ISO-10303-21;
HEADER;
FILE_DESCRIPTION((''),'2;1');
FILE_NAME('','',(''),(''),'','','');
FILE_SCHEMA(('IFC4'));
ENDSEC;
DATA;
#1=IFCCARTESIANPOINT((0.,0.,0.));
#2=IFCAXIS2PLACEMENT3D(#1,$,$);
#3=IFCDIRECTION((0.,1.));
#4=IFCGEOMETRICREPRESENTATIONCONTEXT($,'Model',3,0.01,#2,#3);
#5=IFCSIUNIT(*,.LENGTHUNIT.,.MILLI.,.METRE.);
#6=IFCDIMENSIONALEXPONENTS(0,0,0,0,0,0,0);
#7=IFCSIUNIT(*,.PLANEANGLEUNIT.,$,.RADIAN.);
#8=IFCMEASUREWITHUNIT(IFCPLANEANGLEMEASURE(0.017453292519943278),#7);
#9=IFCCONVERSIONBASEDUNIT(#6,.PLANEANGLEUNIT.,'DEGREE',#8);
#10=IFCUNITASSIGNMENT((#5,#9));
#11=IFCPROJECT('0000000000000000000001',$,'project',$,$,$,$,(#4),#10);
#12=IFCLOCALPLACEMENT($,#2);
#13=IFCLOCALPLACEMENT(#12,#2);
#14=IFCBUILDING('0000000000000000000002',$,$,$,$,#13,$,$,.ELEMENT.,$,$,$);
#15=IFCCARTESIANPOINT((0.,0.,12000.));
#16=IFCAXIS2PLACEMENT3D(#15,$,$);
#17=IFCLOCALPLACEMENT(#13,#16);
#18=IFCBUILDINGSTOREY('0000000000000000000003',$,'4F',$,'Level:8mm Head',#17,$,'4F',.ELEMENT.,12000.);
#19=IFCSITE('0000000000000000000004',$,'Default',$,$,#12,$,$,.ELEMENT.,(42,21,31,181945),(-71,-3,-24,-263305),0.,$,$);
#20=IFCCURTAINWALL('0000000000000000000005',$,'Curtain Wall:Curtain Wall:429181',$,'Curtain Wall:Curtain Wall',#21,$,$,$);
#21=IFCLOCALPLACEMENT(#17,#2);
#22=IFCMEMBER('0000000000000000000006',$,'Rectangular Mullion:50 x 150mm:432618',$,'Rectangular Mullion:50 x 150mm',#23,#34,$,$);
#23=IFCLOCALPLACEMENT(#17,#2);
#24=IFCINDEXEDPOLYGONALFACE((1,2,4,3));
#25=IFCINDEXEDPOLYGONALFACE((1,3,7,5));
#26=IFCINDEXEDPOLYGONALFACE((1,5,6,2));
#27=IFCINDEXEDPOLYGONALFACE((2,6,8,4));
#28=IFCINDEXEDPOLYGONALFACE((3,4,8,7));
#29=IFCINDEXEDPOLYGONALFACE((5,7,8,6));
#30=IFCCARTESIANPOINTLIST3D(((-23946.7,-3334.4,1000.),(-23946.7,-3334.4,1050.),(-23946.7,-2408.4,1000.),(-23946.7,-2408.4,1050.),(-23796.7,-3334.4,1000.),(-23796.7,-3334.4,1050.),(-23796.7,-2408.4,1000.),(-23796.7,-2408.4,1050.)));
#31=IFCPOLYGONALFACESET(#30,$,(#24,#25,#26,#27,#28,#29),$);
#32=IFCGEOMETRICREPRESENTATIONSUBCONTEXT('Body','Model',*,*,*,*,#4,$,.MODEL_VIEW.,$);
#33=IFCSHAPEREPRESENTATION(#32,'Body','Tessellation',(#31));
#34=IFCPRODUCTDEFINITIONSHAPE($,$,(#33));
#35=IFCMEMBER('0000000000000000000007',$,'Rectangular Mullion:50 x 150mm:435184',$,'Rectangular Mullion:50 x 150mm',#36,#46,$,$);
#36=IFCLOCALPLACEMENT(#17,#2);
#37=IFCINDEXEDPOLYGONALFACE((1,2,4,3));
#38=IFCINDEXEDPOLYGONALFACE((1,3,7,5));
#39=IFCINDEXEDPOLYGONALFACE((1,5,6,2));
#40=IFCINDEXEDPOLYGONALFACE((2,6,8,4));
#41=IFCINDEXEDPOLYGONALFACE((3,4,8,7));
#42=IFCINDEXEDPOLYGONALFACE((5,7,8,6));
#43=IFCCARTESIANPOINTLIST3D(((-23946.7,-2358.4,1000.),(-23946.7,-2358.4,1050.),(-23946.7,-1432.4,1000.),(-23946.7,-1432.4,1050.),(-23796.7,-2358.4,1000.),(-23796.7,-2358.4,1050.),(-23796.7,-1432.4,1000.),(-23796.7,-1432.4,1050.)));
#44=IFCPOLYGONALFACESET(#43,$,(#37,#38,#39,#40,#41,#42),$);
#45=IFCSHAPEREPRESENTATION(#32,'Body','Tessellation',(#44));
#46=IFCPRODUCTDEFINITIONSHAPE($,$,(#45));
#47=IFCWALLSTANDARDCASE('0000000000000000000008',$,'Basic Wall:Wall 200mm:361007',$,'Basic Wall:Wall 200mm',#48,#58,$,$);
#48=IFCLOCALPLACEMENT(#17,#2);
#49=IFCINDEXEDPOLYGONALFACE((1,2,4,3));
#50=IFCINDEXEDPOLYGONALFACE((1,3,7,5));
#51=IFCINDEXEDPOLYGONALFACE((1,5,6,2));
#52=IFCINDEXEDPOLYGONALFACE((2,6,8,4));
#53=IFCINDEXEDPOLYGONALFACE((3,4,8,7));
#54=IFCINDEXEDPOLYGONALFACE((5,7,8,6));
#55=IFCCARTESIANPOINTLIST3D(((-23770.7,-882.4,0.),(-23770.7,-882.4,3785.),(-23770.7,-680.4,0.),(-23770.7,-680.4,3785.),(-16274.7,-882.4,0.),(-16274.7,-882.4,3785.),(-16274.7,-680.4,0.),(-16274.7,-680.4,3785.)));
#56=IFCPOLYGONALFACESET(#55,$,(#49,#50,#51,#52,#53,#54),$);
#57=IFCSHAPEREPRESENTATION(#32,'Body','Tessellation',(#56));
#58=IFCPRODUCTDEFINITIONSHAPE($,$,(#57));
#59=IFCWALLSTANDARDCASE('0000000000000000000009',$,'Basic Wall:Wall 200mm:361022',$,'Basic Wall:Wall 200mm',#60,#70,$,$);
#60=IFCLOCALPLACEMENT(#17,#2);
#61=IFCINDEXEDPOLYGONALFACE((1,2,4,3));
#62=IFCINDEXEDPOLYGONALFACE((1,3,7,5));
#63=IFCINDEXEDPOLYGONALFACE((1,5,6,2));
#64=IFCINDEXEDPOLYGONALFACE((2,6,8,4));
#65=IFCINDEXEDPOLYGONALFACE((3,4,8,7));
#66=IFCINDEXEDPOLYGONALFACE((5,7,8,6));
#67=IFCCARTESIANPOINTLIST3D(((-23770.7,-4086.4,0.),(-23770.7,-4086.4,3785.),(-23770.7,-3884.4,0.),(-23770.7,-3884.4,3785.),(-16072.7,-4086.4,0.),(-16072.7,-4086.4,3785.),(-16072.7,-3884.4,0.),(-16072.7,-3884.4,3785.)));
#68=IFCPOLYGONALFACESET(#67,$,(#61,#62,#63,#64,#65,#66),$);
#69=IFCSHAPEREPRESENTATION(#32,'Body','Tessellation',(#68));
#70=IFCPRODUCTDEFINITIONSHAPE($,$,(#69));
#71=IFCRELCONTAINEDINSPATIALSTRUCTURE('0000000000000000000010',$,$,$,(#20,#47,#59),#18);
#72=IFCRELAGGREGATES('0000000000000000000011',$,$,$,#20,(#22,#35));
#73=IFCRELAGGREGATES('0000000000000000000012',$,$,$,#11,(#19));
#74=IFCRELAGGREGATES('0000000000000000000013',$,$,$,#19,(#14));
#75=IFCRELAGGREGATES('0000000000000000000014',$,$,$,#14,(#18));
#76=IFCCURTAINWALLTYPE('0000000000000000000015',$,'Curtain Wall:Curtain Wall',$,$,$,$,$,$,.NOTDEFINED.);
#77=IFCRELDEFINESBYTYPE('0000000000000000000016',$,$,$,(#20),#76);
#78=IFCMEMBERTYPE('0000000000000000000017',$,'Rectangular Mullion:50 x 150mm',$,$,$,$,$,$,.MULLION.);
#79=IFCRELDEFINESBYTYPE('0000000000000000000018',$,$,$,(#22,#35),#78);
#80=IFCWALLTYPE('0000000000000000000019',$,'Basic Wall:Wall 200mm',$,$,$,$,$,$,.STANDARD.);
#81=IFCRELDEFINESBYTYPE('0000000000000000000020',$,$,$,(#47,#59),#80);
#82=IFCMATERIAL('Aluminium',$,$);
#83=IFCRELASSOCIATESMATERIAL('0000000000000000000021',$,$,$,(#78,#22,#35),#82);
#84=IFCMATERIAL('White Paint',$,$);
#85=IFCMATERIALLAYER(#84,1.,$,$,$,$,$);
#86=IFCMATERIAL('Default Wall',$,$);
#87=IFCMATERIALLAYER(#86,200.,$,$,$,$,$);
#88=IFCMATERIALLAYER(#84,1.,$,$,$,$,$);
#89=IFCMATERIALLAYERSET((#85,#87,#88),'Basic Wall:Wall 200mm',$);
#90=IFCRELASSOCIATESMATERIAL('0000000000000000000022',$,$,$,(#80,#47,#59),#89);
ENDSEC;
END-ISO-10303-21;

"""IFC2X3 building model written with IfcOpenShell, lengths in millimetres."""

from ifc_helpers import new_model, entity, si_unit, converted_unit, direction, frame, frame_2d, origin, origin_2d_with_axis, place, context, subcontext, project, spatial, polyline, rectangle, extrude, clip, bounded_halfspace, source, transform, mapped, material, layer, layer_set, layer_usage, type_object, type_shapes, element, aggregate, save


model = new_model("IFC2X3")

# Units and contexts
model_context = context("Model", 3, precision=0.01, world=origin(), true_north=direction((0.0, 1.0)))
body_context = subcontext(model_context, "Body", "Model", "MODEL_VIEW")
ifc_project = project(units=[si_unit("LENGTHUNIT", "METRE", prefix="MILLI"), converted_unit("PLANEANGLEUNIT", "DEGREE", entity("IfcPlaneAngleMeasure", 0.017453292519943278), si_unit("PLANEANGLEUNIT", "RADIAN"), dimensions=[0, 0, 0, 0, 0, 0, 0])], contexts=[model_context])

# Site, building, storey
site_placement = place(None, origin())
site = spatial("IfcSite", under=ifc_project, at=site_placement, Name="Default", CompositionType="ELEMENT", RefLatitude=(42, 21, 31, 181945), RefLongitude=(-71, -3, -24, -263305), RefElevation=0.0)
building_placement = place(site_placement, origin())
building = spatial("IfcBuilding", under=site, at=building_placement, CompositionType="ELEMENT")
storey_placement = place(building_placement, frame((0.0, 0.0, 12000.0)))
storey = spatial("IfcBuildingStorey", under=building, at=storey_placement, Name="4F", ObjectType="Level:8mm Head", LongName="4F", CompositionType="ELEMENT", Elevation=12000.0)

# Curtain wall, members
curtain_wall_type = type_object("IfcCurtainWallType", Name="Curtain Wall:Curtain Wall", PredefinedType="NOTDEFINED")
curtain_wall_placement = place(storey_placement, frame((0.0, 0.0, -12000.0)))
curtain_wall = element("IfcCurtainWall", 1, at=curtain_wall_placement, inside=storey, type_object=curtain_wall_type, Name="Curtain Wall:Curtain Wall:429181", ObjectType="Curtain Wall:Curtain Wall")
ifc_material_1 = material(Name="Aluminium")
member_type_1 = type_object("IfcMemberType", Name="Rectangular Mullion:50 x 150mm", PredefinedType="MULLION", material=ifc_material_1)
shared_shape_1 = source(origin(), body_context, "Body", "SweptSolid", [
    extrude(rectangle(XDim=50.0, YDim=150.0, at=origin_2d_with_axis()), frame((-25.0, 0.0, -926.0), z_axis=(0.0, 0.0, 1.0), x_axis=(-1.0, 0.0, 0.0)), (0.0, 0.0, 1.0), 926.0),
])
type_shapes(member_type_1, [shared_shape_1])
member_1_placement = place(curtain_wall_placement, frame((-23871.7, -3334.4, 13000.0), z_axis=(0.0, -1.0, 0.0), x_axis=(0.0, 0.0, -1.0)))
member_1 = element("IfcMember", 2, at=member_1_placement, type_object=member_type_1, material=ifc_material_1, Name="Rectangular Mullion:50 x 150mm:432618", ObjectType="Rectangular Mullion:50 x 150mm", context=body_context, shape_type="MappedRepresentation", body=[
    mapped(shared_shape_1, transform((0.0, 0.0, 0.0), scale=1.0)),
])
member_2_placement = place(curtain_wall_placement, frame((-23871.7, -2358.4, 13000.0), z_axis=(0.0, -1.0, 0.0), x_axis=(0.0, 0.0, -1.0)))
member_2 = element("IfcMember", 3, at=member_2_placement, type_object=member_type_1, material=ifc_material_1, Name="Rectangular Mullion:50 x 150mm:435184", ObjectType="Rectangular Mullion:50 x 150mm", context=body_context, shape_type="MappedRepresentation", body=[
    mapped(shared_shape_1, transform((0.0, 0.0, 0.0), scale=1.0)),
])
aggregate(curtain_wall, [member_1, member_2])

# Walls
ifc_material_2 = material(Name="White Paint")
ifc_layer_1 = layer(ifc_material_2, 1.0)
ifc_material_3 = material(Name="Default Wall")
ifc_layer_2 = layer(ifc_material_3, 200.0)
ifc_layer_3 = layer(ifc_material_2, 1.0)
ifc_layer_set = layer_set([ifc_layer_1, ifc_layer_2, ifc_layer_3], Name="Basic Wall:Wall 200mm")
ifc_layer_usage_1 = layer_usage(ifc_layer_set, "AXIS2", "POSITIVE", -101.0)
wall_type = type_object("IfcWallType", Name="Basic Wall:Wall 200mm", PredefinedType="STANDARD", material=ifc_layer_set)
wall_1_placement = place(storey_placement, frame((-23770.7, -781.4, 0.0)))
element("IfcWallStandardCase", 4, at=wall_1_placement, inside=storey, type_object=wall_type, material=ifc_layer_usage_1, Name="Basic Wall:Wall 200mm:361007", ObjectType="Basic Wall:Wall 200mm", context=body_context, shape_type="Clipping", body=[
    clip(extrude(rectangle(XDim=7496.0, YDim=202.0, at=frame_2d((3748.0, 0.0), x_axis=(-1.0, 0.0))), origin(), (0.0, 0.0, 1.0), 3785.0), bounded_halfspace(frame((0.0, -101.0, 3785.0), z_axis=(0.0, 0.0, -1.0), x_axis=(0.0, -1.0, 0.0)), True, frame((0.0, -101.0, 3785.0), z_axis=(0.0, 0.0, -1.0), x_axis=(0.0, -1.0, 0.0)), polyline([(0.0, 0.0), (-202.0, 0.0), (-202.0, -496.0), (-202.0, -1196.0), (-202.0, -7496.0), (0.0, -7496.0), (0.0, 0.0)]))),
])
ifc_layer_usage_2 = layer_usage(ifc_layer_set, "AXIS2", "NEGATIVE", 101.0)
wall_2_placement = place(storey_placement, frame((-16072.7, -3985.4, 0.0), z_axis=(0.0, 0.0, 1.0), x_axis=(-1.0, 0.0, 0.0)))
element("IfcWallStandardCase", 5, at=wall_2_placement, inside=storey, type_object=wall_type, material=ifc_layer_usage_2, Name="Basic Wall:Wall 200mm:361022", ObjectType="Basic Wall:Wall 200mm", context=body_context, shape_type="Clipping", body=[
    clip(extrude(rectangle(XDim=7698.0, YDim=202.0, at=frame_2d((3849.0, 0.0), x_axis=(-1.0, 0.0))), origin(), (0.0, 0.0, 1.0), 3785.0), bounded_halfspace(frame((0.0, -101.0, 3785.0), z_axis=(0.0, 0.0, -1.0), x_axis=(0.0, 1.0, 0.0)), True, frame((0.0, -101.0, 3785.0), z_axis=(0.0, 0.0, -1.0), x_axis=(0.0, 1.0, 0.0)), polyline([(0.0, 0.0), (202.0, 0.0), (202.0, 7698.0), (0.0, 7698.0), (0.0, 202.0), (0.0, 0.0)]))),
])

save(model, "model.ifc")
